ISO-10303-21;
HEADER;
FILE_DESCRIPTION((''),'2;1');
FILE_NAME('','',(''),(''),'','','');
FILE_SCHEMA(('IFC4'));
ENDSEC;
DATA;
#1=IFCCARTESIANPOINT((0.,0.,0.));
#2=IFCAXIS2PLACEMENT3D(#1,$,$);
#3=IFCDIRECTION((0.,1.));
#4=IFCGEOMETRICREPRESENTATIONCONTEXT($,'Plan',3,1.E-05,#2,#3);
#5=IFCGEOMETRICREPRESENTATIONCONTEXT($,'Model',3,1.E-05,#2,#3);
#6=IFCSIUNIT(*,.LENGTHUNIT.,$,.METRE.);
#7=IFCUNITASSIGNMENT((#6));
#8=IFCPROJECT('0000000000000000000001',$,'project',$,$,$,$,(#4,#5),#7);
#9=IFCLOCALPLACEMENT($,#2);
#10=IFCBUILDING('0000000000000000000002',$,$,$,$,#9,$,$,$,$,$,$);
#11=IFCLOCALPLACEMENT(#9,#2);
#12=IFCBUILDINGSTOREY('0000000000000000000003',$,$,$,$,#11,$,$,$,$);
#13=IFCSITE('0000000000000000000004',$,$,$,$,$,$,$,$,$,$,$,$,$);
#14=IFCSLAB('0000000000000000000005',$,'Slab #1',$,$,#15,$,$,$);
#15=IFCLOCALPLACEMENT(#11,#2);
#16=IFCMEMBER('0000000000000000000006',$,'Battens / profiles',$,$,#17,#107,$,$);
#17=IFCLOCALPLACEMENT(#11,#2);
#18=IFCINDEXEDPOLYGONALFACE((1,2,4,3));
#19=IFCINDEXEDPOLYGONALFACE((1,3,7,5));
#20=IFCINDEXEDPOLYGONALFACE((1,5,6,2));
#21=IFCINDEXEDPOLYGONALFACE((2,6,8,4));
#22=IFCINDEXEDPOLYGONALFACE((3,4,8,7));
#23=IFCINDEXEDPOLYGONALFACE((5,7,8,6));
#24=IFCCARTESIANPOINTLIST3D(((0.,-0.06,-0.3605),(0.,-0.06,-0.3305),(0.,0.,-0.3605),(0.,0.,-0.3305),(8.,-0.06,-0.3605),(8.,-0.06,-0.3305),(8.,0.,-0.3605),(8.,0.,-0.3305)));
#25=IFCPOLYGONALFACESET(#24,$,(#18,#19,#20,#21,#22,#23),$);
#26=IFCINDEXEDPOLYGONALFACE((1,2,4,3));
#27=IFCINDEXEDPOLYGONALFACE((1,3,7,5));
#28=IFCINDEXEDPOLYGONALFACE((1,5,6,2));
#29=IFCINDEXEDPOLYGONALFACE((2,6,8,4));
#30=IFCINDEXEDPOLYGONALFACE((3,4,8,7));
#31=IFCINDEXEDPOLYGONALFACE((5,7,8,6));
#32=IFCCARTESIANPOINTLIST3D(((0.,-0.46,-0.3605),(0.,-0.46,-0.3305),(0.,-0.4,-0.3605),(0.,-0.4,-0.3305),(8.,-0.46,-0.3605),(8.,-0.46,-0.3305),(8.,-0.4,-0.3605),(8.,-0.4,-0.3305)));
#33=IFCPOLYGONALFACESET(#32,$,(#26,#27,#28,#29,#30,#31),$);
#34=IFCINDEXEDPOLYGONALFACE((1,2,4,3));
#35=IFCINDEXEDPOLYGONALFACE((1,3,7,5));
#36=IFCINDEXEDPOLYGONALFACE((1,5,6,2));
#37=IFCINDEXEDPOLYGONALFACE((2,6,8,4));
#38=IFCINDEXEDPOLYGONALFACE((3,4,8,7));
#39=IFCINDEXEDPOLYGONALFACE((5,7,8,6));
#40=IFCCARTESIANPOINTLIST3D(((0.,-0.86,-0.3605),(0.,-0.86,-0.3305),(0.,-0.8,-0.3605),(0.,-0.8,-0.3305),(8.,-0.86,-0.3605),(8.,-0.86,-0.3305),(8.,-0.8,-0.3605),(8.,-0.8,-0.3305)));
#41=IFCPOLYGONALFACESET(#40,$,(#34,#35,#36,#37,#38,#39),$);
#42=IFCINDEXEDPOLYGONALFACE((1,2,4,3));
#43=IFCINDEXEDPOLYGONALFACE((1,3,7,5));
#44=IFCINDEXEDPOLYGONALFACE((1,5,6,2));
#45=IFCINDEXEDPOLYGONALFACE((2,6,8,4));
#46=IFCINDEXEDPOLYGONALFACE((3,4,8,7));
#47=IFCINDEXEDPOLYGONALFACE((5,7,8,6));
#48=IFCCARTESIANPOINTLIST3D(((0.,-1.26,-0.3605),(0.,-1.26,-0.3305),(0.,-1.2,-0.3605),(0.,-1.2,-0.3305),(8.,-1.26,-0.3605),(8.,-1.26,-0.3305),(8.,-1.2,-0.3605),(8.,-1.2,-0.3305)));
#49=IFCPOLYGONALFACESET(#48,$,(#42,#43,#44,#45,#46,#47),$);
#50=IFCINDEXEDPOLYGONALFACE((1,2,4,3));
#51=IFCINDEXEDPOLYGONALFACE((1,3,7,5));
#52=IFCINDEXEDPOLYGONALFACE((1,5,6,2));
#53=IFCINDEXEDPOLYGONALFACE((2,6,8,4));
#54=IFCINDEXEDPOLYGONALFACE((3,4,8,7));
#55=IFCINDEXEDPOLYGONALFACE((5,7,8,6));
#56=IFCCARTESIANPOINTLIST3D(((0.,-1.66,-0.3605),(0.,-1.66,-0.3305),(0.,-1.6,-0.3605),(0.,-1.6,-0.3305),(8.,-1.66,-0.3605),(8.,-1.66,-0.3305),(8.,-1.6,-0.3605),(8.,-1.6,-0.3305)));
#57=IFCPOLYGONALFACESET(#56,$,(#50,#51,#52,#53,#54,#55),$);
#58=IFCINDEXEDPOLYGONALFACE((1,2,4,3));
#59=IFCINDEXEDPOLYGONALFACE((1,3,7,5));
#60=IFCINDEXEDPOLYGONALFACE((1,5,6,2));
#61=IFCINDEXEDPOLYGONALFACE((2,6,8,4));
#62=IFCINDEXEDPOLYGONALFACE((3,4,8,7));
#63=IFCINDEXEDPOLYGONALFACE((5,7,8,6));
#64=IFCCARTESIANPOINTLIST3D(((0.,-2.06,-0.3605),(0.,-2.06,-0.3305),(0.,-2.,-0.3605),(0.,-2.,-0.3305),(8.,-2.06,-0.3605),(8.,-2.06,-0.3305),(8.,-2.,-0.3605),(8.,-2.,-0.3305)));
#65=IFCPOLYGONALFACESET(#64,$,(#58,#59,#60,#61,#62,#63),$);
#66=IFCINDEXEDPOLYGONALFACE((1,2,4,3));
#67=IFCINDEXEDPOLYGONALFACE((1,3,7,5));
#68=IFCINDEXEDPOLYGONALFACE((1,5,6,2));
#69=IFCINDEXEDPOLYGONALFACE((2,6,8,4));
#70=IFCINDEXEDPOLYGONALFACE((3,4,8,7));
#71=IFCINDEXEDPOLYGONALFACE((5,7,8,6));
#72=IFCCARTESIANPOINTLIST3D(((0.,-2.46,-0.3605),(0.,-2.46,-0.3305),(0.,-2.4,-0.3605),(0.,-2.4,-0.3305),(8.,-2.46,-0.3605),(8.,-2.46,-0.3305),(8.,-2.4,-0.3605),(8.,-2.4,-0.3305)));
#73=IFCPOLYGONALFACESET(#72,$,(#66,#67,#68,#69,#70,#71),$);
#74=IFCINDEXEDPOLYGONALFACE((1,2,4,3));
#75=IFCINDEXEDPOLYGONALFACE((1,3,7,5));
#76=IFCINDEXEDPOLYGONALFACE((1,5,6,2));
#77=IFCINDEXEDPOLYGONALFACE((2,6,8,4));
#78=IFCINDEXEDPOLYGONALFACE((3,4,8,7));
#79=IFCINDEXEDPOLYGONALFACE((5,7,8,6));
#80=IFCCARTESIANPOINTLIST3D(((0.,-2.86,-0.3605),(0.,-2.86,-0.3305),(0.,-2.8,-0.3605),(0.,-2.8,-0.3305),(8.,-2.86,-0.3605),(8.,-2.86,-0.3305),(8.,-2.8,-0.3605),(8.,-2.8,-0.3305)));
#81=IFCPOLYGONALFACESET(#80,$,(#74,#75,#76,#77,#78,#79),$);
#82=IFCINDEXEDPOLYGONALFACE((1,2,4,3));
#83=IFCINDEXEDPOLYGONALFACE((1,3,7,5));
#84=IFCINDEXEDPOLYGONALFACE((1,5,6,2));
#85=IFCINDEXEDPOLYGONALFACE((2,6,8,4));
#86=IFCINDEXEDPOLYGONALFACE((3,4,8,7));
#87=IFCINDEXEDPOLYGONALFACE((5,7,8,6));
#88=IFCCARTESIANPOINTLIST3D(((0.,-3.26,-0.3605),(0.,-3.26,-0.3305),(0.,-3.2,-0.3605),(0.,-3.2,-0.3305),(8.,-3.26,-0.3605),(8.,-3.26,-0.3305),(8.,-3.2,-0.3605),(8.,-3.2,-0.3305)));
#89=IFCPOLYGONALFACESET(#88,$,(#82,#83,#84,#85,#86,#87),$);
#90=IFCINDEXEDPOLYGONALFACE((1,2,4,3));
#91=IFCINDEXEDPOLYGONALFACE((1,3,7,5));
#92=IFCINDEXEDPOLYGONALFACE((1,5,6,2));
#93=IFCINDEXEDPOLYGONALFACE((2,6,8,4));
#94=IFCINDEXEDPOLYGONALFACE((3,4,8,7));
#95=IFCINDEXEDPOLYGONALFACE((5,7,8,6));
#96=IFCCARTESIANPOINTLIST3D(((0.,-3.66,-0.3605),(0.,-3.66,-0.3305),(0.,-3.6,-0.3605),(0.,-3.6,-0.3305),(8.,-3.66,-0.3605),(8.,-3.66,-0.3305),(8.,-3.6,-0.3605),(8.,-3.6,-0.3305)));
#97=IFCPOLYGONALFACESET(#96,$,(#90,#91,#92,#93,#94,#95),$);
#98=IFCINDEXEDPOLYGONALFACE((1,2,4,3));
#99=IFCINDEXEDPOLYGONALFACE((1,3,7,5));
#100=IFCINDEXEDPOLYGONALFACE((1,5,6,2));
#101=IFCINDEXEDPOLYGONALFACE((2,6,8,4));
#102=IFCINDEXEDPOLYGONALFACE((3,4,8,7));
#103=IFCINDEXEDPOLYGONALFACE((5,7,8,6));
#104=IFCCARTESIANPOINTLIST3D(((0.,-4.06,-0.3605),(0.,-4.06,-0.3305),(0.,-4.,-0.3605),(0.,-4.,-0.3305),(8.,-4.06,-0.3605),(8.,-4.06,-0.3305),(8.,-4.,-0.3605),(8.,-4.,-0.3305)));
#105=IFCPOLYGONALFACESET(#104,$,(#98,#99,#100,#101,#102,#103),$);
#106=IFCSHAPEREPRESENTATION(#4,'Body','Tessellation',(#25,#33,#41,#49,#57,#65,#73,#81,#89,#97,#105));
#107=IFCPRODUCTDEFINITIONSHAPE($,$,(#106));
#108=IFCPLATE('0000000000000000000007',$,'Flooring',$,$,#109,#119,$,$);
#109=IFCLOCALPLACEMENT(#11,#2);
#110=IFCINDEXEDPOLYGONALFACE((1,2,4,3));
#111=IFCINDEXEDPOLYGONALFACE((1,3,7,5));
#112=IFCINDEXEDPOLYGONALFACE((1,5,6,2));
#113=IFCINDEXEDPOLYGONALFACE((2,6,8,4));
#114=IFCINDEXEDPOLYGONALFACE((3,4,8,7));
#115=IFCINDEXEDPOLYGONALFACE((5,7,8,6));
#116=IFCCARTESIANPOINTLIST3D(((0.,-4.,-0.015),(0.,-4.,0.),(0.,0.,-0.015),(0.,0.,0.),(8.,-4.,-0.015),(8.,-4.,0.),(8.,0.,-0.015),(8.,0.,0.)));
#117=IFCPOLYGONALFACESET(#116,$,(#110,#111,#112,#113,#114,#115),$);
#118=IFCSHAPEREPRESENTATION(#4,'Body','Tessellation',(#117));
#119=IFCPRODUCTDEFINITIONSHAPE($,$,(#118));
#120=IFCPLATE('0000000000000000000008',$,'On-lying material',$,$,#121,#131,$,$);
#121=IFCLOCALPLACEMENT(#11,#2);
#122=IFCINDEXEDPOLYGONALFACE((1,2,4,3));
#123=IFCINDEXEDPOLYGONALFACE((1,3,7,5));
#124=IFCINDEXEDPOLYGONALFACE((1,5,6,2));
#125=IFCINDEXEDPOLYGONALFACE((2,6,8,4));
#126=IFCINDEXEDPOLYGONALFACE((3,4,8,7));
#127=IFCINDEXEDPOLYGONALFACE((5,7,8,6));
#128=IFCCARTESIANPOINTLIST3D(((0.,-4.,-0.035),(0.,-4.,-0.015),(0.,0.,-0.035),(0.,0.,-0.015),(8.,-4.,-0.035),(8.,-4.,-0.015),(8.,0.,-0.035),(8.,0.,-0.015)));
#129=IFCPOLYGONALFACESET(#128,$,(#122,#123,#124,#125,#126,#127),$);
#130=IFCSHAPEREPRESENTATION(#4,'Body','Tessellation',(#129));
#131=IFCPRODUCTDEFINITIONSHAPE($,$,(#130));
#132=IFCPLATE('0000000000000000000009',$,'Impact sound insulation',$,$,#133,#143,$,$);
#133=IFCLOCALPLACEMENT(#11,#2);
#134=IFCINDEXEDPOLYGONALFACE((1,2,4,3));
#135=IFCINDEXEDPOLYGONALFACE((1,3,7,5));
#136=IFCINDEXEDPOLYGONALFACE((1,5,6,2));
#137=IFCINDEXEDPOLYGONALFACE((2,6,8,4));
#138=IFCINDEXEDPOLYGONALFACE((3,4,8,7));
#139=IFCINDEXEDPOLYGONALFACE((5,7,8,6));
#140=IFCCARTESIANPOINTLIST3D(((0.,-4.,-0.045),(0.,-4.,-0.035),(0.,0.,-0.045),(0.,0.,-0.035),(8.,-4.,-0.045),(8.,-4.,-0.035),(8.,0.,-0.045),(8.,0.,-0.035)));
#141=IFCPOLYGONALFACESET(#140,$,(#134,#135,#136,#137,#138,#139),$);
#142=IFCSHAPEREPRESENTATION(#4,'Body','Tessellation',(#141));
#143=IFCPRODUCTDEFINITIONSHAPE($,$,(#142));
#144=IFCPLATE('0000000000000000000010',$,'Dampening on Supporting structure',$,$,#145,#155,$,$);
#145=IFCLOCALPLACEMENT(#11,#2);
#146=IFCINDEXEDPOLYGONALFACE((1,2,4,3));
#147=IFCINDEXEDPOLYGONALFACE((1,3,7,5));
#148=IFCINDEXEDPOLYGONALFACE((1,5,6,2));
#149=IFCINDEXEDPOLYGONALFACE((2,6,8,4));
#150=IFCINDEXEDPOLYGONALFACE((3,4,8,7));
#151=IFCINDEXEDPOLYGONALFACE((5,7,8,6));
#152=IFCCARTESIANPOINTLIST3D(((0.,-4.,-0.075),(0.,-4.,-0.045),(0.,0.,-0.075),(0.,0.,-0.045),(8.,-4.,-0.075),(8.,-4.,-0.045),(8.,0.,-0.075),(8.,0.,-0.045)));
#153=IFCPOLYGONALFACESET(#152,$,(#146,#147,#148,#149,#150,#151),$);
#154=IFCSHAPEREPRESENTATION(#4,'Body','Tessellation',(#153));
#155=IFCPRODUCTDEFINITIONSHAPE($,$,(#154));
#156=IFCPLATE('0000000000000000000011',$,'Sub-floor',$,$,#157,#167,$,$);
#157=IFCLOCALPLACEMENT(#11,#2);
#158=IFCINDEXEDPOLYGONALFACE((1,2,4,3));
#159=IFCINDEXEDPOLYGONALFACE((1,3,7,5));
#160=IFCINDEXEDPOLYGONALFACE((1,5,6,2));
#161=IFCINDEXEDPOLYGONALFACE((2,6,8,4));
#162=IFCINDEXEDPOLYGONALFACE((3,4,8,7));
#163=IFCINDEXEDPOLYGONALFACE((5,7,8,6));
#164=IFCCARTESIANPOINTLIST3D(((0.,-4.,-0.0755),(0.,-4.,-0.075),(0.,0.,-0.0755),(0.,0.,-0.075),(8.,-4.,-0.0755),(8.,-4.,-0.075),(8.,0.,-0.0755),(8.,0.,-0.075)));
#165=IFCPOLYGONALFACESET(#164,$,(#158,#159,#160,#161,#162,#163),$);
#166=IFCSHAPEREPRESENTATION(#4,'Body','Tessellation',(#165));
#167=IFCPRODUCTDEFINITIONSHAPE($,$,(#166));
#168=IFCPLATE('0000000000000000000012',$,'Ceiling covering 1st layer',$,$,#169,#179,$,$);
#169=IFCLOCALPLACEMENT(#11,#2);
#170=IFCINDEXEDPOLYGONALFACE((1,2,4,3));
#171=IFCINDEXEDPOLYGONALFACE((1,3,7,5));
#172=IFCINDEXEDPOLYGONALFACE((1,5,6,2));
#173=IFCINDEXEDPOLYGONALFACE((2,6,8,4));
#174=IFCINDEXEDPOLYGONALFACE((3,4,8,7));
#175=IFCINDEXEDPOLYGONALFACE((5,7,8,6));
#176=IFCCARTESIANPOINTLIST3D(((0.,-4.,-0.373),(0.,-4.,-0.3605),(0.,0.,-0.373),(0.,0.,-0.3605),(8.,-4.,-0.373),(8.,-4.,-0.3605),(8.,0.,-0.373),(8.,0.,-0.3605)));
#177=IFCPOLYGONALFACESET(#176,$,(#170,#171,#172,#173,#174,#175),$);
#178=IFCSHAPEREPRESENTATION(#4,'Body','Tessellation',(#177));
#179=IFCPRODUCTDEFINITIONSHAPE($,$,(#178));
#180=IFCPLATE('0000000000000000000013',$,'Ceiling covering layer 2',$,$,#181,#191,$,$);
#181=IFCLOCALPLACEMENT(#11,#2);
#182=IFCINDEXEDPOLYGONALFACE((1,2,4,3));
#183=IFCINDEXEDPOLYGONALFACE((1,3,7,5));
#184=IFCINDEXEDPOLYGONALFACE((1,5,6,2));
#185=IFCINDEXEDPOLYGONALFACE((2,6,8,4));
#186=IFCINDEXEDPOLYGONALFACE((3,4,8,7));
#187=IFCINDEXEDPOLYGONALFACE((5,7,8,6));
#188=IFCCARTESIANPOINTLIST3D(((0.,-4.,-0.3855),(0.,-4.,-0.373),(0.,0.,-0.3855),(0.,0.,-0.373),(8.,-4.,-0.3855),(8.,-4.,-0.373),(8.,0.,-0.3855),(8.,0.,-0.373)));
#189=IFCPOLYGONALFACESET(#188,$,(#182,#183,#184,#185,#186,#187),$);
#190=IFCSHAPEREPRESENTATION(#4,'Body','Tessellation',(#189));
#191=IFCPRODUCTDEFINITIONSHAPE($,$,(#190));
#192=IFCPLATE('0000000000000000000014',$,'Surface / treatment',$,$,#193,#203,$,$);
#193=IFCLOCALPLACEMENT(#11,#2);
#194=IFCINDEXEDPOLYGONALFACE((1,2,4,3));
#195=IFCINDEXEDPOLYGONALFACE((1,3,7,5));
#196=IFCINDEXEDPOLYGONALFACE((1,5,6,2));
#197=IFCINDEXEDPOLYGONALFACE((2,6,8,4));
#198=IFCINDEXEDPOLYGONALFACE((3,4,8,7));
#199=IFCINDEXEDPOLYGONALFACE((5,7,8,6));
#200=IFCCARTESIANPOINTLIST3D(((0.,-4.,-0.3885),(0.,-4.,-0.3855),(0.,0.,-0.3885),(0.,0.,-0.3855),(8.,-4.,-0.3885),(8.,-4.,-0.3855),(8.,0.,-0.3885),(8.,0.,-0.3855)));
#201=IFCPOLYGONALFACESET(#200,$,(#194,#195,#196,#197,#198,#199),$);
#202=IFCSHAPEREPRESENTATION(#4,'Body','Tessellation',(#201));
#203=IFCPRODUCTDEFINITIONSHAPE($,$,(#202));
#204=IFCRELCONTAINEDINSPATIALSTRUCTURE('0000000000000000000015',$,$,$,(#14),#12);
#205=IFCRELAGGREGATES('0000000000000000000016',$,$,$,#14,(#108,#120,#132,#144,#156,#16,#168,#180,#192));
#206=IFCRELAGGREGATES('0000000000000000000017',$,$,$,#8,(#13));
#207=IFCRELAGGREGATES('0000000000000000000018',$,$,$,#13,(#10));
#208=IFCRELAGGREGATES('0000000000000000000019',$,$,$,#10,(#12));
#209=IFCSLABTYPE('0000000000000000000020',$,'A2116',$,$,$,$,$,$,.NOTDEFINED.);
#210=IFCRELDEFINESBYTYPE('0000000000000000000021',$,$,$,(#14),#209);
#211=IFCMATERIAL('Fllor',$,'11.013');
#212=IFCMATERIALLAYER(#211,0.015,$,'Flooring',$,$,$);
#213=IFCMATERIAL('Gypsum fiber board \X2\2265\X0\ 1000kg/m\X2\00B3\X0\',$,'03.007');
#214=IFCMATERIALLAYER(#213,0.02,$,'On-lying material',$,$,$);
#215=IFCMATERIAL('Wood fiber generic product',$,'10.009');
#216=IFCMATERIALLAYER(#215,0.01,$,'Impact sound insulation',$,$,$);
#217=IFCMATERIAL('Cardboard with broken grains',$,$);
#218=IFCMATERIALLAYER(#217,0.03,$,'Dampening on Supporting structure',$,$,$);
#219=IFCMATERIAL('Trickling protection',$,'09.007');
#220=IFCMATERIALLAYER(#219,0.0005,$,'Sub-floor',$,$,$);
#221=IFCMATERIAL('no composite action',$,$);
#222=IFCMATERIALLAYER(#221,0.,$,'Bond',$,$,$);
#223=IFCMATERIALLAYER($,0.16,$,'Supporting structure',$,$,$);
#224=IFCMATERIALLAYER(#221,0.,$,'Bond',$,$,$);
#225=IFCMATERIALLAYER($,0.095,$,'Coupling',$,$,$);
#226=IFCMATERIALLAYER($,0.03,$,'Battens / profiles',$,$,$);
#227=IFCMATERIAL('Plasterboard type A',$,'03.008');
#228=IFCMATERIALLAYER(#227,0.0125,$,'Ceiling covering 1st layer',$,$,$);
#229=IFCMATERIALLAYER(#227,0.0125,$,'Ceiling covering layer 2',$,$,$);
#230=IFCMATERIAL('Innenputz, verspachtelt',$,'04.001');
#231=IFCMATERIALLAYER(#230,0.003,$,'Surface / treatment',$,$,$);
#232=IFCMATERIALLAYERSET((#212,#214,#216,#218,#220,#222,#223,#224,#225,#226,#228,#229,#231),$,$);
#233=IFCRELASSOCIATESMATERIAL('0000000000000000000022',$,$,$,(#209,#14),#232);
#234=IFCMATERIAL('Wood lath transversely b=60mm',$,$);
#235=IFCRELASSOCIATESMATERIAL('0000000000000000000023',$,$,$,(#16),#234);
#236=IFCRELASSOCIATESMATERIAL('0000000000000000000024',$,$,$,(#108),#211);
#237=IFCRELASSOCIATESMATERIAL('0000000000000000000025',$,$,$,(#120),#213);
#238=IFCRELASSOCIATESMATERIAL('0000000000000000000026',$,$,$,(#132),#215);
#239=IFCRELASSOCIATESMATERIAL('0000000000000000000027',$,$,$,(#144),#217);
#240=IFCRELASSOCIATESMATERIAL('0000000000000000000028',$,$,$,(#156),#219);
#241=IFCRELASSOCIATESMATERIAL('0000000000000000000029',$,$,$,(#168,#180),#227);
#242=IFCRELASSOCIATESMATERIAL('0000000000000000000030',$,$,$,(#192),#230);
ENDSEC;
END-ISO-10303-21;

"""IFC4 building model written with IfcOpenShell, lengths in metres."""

from ifc_helpers import new_model, si_unit, direction, frame, frame_2d, origin, origin_with_axes, place, context, project, spatial, rectangle, extrude, material, layer, layer_set, type_object, element, aggregate, save


model = new_model("IFC4")

# Units and contexts
plan_context = context("Plan", 3, precision=1e-05, world=origin(), true_north=direction((0.0, 1.0)))
model_context = context("Model", 3, precision=1e-05, world=origin(), true_north=direction((0.0, 1.0)))
ifc_project = project(units=[si_unit("LENGTHUNIT", "METRE")], contexts=[plan_context, model_context])

# Site, building, storey
site = spatial("IfcSite", under=ifc_project)
building_placement = place(None, origin())
building = spatial("IfcBuilding", under=site, at=building_placement)
storey_placement = place(building_placement, origin())
storey = spatial("IfcBuildingStorey", under=building, at=storey_placement)

# Slab, member, plates
ifc_material_1 = material(Name="Fllor", Category="11.013")
ifc_layer_1 = layer(ifc_material_1, 0.015, Name="Flooring")
ifc_material_2 = material(Name="Gypsum fiber board ≥ 1000kg/m³", Category="03.007")
ifc_layer_2 = layer(ifc_material_2, 0.02, Name="On-lying material")
ifc_material_3 = material(Name="Wood fiber generic product", Category="10.009")
ifc_layer_3 = layer(ifc_material_3, 0.01, Name="Impact sound insulation")
ifc_material_4 = material(Name="Cardboard with broken grains")
ifc_layer_4 = layer(ifc_material_4, 0.03, Name="Dampening on Supporting structure")
ifc_material_5 = material(Name="Trickling protection", Category="09.007")
ifc_layer_5 = layer(ifc_material_5, 0.0005, Name="Sub-floor")
ifc_material_6 = material(Name="no composite action")
ifc_layer_6 = layer(ifc_material_6, 0.0, Name="Bond")
ifc_layer_7 = layer(None, 0.16, Name="Supporting structure")
ifc_layer_8 = layer(ifc_material_6, 0.0, Name="Bond")
ifc_layer_9 = layer(None, 0.095, Name="Coupling")
ifc_layer_10 = layer(None, 0.03, Name="Battens / profiles")
ifc_material_7 = material(Name="Plasterboard type A", Category="03.008")
ifc_layer_11 = layer(ifc_material_7, 0.0125, Name="Ceiling covering 1st layer")
ifc_layer_12 = layer(ifc_material_7, 0.0125, Name="Ceiling covering layer 2")
ifc_material_8 = material(Name="Innenputz, verspachtelt", Category="04.001")
ifc_layer_13 = layer(ifc_material_8, 0.003, Name="Surface / treatment")
ifc_layer_set = layer_set([ifc_layer_1, ifc_layer_2, ifc_layer_3, ifc_layer_4, ifc_layer_5, ifc_layer_6, ifc_layer_7, ifc_layer_8, ifc_layer_9, ifc_layer_10, ifc_layer_11, ifc_layer_12, ifc_layer_13])
slab_type = type_object("IfcSlabType", Name="A2116", PredefinedType="NOTDEFINED", material=ifc_layer_set)
slab_placement = place(None, frame((0.0, 0.0, 0.0), z_axis=(0.0, 0.0, -1.0), x_axis=(1.0, 0.0, 0.0)))
slab = element("IfcSlab", 1, at=slab_placement, inside=storey, type_object=slab_type, material=ifc_layer_set, Name="Slab #1")
ifc_material_9 = material(Name="Wood lath transversely b=60mm")
member_1_placement = place(slab_placement, origin())
member_1 = element("IfcMember", 2, at=member_1_placement, material=ifc_material_9, Name="Battens / profiles", context=plan_context, shape_type="SweptSolid", body=[
    extrude(rectangle(XDim=0.06, YDim=0.03, at=frame_2d((0.03, 0.015), x_axis=(1.0, 0.0))), frame((0.0, 0.0, 0.3305), z_axis=(1.0, 0.0, 0.0), x_axis=(0.0, 1.0, 0.0)), (0.0, 0.0, 1.0), 8.0),
    extrude(rectangle(XDim=0.06, YDim=0.03, at=frame_2d((0.03, 0.015), x_axis=(1.0, 0.0))), frame((0.0, 0.4, 0.3305), z_axis=(1.0, 0.0, 0.0), x_axis=(0.0, 1.0, 0.0)), (0.0, 0.0, 1.0), 8.0),
    extrude(rectangle(XDim=0.06, YDim=0.03, at=frame_2d((0.03, 0.015), x_axis=(1.0, 0.0))), frame((0.0, 0.8, 0.3305), z_axis=(1.0, 0.0, 0.0), x_axis=(0.0, 1.0, 0.0)), (0.0, 0.0, 1.0), 8.0),
    extrude(rectangle(XDim=0.06, YDim=0.03, at=frame_2d((0.03, 0.015), x_axis=(1.0, 0.0))), frame((0.0, 1.2, 0.3305), z_axis=(1.0, 0.0, 0.0), x_axis=(0.0, 1.0, 0.0)), (0.0, 0.0, 1.0), 8.0),
    extrude(rectangle(XDim=0.06, YDim=0.03, at=frame_2d((0.03, 0.015), x_axis=(1.0, 0.0))), frame((0.0, 1.6, 0.3305), z_axis=(1.0, 0.0, 0.0), x_axis=(0.0, 1.0, 0.0)), (0.0, 0.0, 1.0), 8.0),
    extrude(rectangle(XDim=0.06, YDim=0.03, at=frame_2d((0.03, 0.015), x_axis=(1.0, 0.0))), frame((0.0, 2.0, 0.3305), z_axis=(1.0, 0.0, 0.0), x_axis=(0.0, 1.0, 0.0)), (0.0, 0.0, 1.0), 8.0),
    extrude(rectangle(XDim=0.06, YDim=0.03, at=frame_2d((0.03, 0.015), x_axis=(1.0, 0.0))), frame((0.0, 2.4, 0.3305), z_axis=(1.0, 0.0, 0.0), x_axis=(0.0, 1.0, 0.0)), (0.0, 0.0, 1.0), 8.0),
    extrude(rectangle(XDim=0.06, YDim=0.03, at=frame_2d((0.03, 0.015), x_axis=(1.0, 0.0))), frame((0.0, 2.8, 0.3305), z_axis=(1.0, 0.0, 0.0), x_axis=(0.0, 1.0, 0.0)), (0.0, 0.0, 1.0), 8.0),
    extrude(rectangle(XDim=0.06, YDim=0.03, at=frame_2d((0.03, 0.015), x_axis=(1.0, 0.0))), frame((0.0, 3.2, 0.3305), z_axis=(1.0, 0.0, 0.0), x_axis=(0.0, 1.0, 0.0)), (0.0, 0.0, 1.0), 8.0),
    extrude(rectangle(XDim=0.06, YDim=0.03, at=frame_2d((0.03, 0.015), x_axis=(1.0, 0.0))), frame((0.0, 3.6, 0.3305), z_axis=(1.0, 0.0, 0.0), x_axis=(0.0, 1.0, 0.0)), (0.0, 0.0, 1.0), 8.0),
    extrude(rectangle(XDim=0.06, YDim=0.03, at=frame_2d((0.03, 0.015), x_axis=(1.0, 0.0))), frame((0.0, 4.0, 0.3305), z_axis=(1.0, 0.0, 0.0), x_axis=(0.0, 1.0, 0.0)), (0.0, 0.0, 1.0), 8.0),
])
plate_1_placement = place(slab_placement, origin())
plate_1 = element("IfcPlate", 3, at=plate_1_placement, material=ifc_material_1, Name="Flooring", context=plan_context, shape_type="SweptSolid", body=[
    extrude(rectangle(XDim=8.0, YDim=4.0, at=frame_2d((4.0, 2.0), x_axis=(1.0, 0.0))), origin_with_axes(), (0.0, 0.0, 1.0), 0.015),
])
plate_2_placement = place(slab_placement, origin())
plate_2 = element("IfcPlate", 4, at=plate_2_placement, material=ifc_material_2, Name="On-lying material", context=plan_context, shape_type="SweptSolid", body=[
    extrude(rectangle(XDim=8.0, YDim=4.0, at=frame_2d((4.0, 2.0), x_axis=(1.0, 0.0))), frame((0.0, 0.0, 0.015), z_axis=(0.0, 0.0, 1.0), x_axis=(1.0, 0.0, 0.0)), (0.0, 0.0, 1.0), 0.02),
])
plate_3_placement = place(slab_placement, origin())
plate_3 = element("IfcPlate", 5, at=plate_3_placement, material=ifc_material_3, Name="Impact sound insulation", context=plan_context, shape_type="SweptSolid", body=[
    extrude(rectangle(XDim=8.0, YDim=4.0, at=frame_2d((4.0, 2.0), x_axis=(1.0, 0.0))), frame((0.0, 0.0, 0.035), z_axis=(0.0, 0.0, 1.0), x_axis=(1.0, 0.0, 0.0)), (0.0, 0.0, 1.0), 0.01),
])
plate_4_placement = place(slab_placement, origin())
plate_4 = element("IfcPlate", 6, at=plate_4_placement, material=ifc_material_4, Name="Dampening on Supporting structure", context=plan_context, shape_type="SweptSolid", body=[
    extrude(rectangle(XDim=8.0, YDim=4.0, at=frame_2d((4.0, 2.0), x_axis=(1.0, 0.0))), frame((0.0, 0.0, 0.045), z_axis=(0.0, 0.0, 1.0), x_axis=(1.0, 0.0, 0.0)), (0.0, 0.0, 1.0), 0.03),
])
plate_5_placement = place(slab_placement, origin())
plate_5 = element("IfcPlate", 7, at=plate_5_placement, material=ifc_material_5, Name="Sub-floor", context=plan_context, shape_type="SweptSolid", body=[
    extrude(rectangle(XDim=8.0, YDim=4.0, at=frame_2d((4.0, 2.0), x_axis=(1.0, 0.0))), frame((0.0, 0.0, 0.075), z_axis=(0.0, 0.0, 1.0), x_axis=(1.0, 0.0, 0.0)), (0.0, 0.0, 1.0), 0.0005),
])
plate_6_placement = place(slab_placement, origin())
plate_6 = element("IfcPlate", 8, at=plate_6_placement, material=ifc_material_7, Name="Ceiling covering 1st layer", context=plan_context, shape_type="SweptSolid", body=[
    extrude(rectangle(XDim=8.0, YDim=4.0, at=frame_2d((4.0, 2.0), x_axis=(1.0, 0.0))), frame((0.0, 0.0, 0.3605), z_axis=(0.0, 0.0, 1.0), x_axis=(1.0, 0.0, 0.0)), (0.0, 0.0, 1.0), 0.0125),
])
plate_7_placement = place(slab_placement, origin())
plate_7 = element("IfcPlate", 9, at=plate_7_placement, material=ifc_material_7, Name="Ceiling covering layer 2", context=plan_context, shape_type="SweptSolid", body=[
    extrude(rectangle(XDim=8.0, YDim=4.0, at=frame_2d((4.0, 2.0), x_axis=(1.0, 0.0))), frame((0.0, 0.0, 0.373), z_axis=(0.0, 0.0, 1.0), x_axis=(1.0, 0.0, 0.0)), (0.0, 0.0, 1.0), 0.0125),
])
plate_8_placement = place(slab_placement, origin())
plate_8 = element("IfcPlate", 10, at=plate_8_placement, material=ifc_material_8, Name="Surface / treatment", context=plan_context, shape_type="SweptSolid", body=[
    extrude(rectangle(XDim=8.0, YDim=4.0, at=frame_2d((4.0, 2.0), x_axis=(1.0, 0.0))), frame((0.0, 0.0, 0.3855), z_axis=(0.0, 0.0, 1.0), x_axis=(1.0, 0.0, 0.0)), (0.0, 0.0, 1.0), 0.003),
])
aggregate(slab, [plate_1, plate_2, plate_3, plate_4, plate_5, member_1, plate_6, plate_7, plate_8])

save(model, "model.ifc")
